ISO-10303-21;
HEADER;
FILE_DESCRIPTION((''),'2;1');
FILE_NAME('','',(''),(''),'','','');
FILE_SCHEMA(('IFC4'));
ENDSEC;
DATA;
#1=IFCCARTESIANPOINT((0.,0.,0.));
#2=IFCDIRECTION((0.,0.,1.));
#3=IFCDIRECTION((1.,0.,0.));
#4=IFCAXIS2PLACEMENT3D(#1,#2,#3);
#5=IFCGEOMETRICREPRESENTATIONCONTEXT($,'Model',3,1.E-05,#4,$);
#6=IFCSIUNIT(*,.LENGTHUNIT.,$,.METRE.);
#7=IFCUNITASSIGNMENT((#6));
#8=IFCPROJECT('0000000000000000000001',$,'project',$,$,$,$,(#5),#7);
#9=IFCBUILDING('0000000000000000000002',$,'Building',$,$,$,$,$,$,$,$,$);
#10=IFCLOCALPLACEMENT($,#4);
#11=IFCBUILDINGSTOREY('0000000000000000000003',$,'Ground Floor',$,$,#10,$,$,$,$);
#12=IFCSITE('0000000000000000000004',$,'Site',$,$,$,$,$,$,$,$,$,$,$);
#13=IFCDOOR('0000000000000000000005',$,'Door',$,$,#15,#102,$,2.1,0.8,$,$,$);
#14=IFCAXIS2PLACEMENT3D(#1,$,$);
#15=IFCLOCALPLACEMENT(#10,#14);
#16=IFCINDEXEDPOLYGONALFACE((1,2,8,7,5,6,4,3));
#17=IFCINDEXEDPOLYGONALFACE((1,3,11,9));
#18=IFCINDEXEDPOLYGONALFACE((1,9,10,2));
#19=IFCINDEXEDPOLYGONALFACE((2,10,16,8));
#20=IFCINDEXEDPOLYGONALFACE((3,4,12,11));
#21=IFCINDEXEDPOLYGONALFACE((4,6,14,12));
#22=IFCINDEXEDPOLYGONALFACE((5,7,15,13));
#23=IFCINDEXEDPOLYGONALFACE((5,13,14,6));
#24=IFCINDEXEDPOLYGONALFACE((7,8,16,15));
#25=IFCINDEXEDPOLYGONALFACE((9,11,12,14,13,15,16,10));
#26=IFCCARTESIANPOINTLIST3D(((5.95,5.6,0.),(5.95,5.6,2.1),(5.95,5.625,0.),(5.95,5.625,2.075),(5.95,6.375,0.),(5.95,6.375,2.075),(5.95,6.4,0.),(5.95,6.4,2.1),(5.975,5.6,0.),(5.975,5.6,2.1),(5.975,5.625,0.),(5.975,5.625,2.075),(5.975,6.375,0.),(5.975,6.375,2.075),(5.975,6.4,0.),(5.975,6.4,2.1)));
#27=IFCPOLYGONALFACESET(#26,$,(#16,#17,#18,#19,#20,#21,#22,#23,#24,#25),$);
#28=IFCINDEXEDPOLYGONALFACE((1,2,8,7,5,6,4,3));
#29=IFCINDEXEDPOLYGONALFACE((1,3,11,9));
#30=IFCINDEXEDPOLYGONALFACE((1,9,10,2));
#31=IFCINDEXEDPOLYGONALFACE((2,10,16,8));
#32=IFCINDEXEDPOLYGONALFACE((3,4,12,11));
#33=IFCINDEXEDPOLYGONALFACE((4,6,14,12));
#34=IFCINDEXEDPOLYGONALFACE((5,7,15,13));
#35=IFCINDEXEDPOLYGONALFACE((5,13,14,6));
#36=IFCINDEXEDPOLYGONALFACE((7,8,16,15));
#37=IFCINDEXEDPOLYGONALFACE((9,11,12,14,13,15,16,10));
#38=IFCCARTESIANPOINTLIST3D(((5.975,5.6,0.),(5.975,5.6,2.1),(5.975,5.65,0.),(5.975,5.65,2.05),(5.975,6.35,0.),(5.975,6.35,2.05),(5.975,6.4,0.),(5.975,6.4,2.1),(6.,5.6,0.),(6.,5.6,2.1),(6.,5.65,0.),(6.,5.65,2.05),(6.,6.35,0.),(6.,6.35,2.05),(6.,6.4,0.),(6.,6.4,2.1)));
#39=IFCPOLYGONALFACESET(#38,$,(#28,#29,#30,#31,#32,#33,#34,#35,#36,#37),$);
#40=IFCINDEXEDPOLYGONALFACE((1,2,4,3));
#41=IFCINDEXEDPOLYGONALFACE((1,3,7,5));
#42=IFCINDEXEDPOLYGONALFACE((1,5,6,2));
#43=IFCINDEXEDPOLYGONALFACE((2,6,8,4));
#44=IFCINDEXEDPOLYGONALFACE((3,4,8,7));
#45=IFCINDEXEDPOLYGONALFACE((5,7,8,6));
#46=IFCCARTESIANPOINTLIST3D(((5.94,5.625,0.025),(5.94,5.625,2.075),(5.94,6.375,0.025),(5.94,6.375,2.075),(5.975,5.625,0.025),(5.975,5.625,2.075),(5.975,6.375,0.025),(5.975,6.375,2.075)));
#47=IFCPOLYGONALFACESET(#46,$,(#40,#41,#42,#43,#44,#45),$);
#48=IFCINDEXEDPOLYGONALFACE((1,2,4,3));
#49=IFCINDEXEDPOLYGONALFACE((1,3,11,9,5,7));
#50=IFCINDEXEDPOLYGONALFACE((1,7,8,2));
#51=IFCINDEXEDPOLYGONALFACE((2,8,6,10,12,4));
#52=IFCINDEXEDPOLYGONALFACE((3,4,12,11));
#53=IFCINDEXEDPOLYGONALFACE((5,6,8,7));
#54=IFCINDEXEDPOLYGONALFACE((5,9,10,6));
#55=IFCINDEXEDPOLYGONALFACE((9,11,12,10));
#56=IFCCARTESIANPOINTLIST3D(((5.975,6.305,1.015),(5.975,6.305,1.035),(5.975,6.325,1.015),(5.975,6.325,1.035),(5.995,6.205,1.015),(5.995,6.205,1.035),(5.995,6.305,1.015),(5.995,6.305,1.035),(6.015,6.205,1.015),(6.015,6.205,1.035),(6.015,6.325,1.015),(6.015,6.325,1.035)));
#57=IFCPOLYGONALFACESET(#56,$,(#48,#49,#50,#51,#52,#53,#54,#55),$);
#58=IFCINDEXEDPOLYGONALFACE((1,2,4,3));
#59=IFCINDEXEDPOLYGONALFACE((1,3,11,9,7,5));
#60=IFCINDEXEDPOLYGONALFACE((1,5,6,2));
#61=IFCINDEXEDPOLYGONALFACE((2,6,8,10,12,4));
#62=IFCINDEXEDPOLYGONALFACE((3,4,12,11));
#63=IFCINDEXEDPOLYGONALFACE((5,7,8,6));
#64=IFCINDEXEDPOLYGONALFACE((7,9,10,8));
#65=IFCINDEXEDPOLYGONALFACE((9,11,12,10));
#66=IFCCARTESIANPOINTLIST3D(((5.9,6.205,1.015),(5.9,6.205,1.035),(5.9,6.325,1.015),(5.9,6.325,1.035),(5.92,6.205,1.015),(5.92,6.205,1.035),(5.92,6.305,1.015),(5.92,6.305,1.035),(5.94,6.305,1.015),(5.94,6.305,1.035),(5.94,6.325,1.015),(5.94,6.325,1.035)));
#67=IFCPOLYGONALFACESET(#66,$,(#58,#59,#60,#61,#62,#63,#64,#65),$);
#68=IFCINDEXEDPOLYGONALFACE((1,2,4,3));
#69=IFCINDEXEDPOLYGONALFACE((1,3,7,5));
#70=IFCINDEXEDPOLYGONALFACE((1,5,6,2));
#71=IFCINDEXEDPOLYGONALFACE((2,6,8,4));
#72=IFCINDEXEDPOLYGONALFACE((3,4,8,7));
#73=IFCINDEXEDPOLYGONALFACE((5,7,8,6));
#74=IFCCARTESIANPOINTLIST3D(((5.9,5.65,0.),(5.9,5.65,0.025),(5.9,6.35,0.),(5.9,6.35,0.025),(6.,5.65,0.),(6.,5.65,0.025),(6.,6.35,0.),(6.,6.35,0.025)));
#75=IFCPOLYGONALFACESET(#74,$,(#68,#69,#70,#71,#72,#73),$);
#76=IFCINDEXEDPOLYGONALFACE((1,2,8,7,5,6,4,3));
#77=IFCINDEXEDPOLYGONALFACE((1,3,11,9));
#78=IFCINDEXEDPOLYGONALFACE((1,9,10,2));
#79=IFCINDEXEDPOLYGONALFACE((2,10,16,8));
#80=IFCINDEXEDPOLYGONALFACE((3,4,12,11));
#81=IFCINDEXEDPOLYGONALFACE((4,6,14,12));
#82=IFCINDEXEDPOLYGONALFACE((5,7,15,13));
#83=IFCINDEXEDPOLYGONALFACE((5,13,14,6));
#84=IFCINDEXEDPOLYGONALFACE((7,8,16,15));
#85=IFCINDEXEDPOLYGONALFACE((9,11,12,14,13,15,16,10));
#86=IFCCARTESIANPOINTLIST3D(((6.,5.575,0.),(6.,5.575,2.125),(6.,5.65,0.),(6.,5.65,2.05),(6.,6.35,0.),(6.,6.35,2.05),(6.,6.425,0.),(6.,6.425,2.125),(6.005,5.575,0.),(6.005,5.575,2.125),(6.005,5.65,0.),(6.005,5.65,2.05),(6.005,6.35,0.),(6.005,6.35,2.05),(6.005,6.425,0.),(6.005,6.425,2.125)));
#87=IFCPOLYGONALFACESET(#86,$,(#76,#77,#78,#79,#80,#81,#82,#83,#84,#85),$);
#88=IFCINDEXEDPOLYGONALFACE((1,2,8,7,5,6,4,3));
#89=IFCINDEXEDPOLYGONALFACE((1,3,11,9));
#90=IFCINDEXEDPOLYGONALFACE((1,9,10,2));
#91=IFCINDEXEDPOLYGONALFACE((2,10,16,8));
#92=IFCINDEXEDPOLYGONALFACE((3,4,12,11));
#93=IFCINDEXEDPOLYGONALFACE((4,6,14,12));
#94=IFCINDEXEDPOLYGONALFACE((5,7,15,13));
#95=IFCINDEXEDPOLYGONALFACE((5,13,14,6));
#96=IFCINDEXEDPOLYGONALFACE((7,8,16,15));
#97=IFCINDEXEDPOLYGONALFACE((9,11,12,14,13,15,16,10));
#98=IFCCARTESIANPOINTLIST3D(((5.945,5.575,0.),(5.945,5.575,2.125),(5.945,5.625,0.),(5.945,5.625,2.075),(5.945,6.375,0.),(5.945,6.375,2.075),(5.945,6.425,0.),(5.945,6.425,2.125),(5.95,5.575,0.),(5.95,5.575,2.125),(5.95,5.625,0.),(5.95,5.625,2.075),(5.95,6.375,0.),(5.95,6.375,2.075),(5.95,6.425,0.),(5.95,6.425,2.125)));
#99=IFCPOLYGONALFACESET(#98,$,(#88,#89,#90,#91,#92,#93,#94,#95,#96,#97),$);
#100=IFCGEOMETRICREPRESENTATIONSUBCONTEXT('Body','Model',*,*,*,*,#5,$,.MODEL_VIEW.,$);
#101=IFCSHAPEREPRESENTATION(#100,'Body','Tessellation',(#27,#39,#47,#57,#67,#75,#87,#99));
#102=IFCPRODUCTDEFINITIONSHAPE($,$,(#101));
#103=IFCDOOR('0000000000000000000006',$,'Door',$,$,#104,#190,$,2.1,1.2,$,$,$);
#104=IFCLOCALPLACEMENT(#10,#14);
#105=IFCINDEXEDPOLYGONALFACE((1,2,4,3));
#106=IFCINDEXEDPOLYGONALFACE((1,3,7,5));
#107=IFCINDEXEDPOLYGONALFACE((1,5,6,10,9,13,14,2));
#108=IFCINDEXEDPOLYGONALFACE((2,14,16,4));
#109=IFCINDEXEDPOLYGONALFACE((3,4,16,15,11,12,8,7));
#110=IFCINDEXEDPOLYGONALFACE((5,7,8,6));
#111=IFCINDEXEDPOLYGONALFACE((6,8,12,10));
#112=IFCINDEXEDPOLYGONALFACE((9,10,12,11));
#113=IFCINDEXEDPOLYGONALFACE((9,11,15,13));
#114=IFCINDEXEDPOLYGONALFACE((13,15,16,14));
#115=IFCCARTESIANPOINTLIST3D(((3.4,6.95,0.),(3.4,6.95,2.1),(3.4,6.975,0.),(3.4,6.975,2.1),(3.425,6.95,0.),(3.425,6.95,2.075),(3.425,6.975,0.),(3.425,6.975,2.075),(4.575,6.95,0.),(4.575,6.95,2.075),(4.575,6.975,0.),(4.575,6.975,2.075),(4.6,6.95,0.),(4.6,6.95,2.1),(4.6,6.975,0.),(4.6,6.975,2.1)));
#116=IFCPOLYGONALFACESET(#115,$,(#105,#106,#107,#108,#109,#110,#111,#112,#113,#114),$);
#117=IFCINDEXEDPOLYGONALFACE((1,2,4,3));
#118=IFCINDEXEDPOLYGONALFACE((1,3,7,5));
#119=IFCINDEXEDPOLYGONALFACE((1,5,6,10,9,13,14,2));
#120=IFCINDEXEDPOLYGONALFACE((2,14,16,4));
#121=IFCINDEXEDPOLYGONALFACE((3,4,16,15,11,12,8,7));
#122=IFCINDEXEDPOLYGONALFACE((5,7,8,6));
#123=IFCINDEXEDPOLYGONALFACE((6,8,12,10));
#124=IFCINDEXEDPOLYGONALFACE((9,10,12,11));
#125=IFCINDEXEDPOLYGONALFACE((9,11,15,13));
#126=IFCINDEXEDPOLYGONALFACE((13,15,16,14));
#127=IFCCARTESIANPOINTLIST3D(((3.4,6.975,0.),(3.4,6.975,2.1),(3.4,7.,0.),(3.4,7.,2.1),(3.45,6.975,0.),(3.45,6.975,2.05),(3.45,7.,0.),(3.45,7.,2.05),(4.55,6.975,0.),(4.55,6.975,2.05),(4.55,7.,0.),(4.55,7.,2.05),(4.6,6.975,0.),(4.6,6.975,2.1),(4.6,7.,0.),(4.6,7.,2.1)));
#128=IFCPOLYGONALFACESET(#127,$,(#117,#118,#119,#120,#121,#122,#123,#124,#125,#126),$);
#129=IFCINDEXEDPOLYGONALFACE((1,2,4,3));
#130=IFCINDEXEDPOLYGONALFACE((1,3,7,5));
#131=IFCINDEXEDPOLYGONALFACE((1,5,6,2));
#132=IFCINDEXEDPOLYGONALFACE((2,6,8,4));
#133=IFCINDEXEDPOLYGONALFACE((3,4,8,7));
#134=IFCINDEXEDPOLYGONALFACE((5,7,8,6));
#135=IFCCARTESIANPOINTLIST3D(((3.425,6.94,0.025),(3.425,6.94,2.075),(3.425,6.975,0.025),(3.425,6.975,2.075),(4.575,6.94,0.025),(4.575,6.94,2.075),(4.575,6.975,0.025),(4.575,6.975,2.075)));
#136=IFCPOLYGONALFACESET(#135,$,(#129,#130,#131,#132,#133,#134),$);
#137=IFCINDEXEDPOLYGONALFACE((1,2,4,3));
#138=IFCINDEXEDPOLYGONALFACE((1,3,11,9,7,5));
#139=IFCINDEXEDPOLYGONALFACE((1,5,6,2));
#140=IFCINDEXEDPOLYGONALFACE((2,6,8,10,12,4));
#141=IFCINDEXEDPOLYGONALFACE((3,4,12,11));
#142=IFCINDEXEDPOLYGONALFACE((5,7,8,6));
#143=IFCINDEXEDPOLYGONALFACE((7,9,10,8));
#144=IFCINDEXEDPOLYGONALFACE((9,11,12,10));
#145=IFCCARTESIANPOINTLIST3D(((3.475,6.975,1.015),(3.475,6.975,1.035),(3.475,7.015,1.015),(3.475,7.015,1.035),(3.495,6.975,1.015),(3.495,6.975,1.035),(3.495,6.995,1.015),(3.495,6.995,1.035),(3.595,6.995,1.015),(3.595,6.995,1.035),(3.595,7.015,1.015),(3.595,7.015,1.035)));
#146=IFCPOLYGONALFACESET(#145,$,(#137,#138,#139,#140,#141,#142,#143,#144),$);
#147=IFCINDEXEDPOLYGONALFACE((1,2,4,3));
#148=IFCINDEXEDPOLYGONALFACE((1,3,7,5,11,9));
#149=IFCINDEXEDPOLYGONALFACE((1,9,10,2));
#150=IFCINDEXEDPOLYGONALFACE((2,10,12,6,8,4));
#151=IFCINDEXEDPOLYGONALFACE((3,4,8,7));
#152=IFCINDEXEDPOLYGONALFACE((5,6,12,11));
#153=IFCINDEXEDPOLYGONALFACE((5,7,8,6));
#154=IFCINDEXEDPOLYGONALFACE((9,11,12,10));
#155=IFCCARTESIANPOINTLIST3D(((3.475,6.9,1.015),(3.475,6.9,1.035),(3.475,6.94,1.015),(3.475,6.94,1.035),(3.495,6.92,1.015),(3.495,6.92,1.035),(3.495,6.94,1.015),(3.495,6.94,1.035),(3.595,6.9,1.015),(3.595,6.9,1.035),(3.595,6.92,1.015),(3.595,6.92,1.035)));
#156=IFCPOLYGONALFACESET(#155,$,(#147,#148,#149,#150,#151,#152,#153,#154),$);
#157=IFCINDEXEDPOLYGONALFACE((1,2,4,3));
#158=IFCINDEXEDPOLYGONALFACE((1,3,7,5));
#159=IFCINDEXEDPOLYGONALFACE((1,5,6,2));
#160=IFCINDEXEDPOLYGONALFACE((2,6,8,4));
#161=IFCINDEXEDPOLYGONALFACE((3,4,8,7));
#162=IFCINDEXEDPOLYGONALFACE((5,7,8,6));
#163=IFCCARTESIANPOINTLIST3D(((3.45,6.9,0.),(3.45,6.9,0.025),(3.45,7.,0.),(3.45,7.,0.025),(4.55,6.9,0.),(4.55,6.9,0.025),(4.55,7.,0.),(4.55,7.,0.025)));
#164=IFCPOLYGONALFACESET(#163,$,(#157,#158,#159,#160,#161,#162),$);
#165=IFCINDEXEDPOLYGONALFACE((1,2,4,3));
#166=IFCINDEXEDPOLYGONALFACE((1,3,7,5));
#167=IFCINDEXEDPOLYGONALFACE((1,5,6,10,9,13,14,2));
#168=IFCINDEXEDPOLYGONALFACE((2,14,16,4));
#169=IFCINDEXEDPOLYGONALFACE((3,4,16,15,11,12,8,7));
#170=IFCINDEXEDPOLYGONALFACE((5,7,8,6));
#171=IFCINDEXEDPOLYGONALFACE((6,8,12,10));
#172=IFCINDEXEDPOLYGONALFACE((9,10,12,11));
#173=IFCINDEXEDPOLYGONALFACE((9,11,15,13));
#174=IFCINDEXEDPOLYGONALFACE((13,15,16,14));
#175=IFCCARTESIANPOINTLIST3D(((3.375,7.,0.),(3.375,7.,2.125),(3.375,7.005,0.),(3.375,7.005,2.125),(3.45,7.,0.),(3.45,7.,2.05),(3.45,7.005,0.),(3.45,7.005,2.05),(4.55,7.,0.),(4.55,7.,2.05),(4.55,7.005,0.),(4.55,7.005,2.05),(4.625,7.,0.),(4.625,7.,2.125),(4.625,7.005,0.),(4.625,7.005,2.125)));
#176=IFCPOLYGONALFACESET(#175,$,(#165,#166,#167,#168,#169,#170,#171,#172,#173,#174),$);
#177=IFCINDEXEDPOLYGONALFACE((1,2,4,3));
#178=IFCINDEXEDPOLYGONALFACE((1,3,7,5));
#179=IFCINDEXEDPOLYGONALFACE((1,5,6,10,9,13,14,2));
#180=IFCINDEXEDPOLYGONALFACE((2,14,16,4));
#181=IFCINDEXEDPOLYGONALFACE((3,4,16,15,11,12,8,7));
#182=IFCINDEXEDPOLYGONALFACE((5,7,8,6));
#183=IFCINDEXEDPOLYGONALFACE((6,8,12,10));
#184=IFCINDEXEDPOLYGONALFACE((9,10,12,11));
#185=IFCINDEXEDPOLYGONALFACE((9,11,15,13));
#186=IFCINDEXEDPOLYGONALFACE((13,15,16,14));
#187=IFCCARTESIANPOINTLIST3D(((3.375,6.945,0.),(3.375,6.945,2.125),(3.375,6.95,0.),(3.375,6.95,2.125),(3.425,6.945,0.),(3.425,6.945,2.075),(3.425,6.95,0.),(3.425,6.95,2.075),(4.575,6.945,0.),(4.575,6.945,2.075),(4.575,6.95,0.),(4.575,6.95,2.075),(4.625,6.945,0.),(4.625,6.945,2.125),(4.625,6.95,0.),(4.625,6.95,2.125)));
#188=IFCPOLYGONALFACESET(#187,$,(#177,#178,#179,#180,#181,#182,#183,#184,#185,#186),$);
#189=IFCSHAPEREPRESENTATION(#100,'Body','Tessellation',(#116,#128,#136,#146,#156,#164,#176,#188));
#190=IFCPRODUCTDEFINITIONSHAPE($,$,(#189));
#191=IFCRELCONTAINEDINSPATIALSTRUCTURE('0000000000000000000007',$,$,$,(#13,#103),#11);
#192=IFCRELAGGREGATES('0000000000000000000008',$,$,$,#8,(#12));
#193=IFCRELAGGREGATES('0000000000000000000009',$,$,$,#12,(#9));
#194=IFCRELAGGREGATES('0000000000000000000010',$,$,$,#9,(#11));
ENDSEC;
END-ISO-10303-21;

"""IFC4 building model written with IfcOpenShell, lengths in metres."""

from ifc_helpers import new_model, si_unit, frame, origin_with_axes, place, context, subcontext, project, spatial, line, indexed_curve, outline, extrude, element, save


model = new_model("IFC4")

# Units and contexts
model_context = context("Model", 3, precision=1e-05, world=origin_with_axes())
body_context = subcontext(model_context, "Body", "Model", "MODEL_VIEW")
ifc_project = project(units=[si_unit("LENGTHUNIT", "METRE")], contexts=[model_context])

# Site, building, storey
site = spatial("IfcSite", under=ifc_project, Name="Site")
building = spatial("IfcBuilding", under=site, Name="Building")
storey_placement = place(None, origin_with_axes())
storey = spatial("IfcBuildingStorey", under=building, at=storey_placement, Name="Ground Floor")

# Doors
door_1_placement = place(storey_placement, frame((6.0, 5.6, 0.0), z_axis=(0.0, 0.0, 1.0), x_axis=(0.0, 1.0, 0.0)))
element("IfcDoor", 1, at=door_1_placement, inside=storey, Name="Door", OverallHeight=2.1, OverallWidth=0.8, context=body_context, shape_type="SweptSolid", body=[
    extrude(outline(indexed_curve([(0.0, 0.0), (0.0, 2.1), (0.8, 2.1), (0.8, 0.0), (0.775, 0.0), (0.775, 2.075), (0.025, 2.075), (0.025, 0.0)], segments=[line(1, 2, 3, 4, 5, 6, 7, 8, 1)])), frame((0.0, 0.025, 0.0), z_axis=(0.0, -1.0, 0.0), x_axis=(1.0, 0.0, 0.0)), (0.0, 0.0, -1.0), 0.025),
    extrude(outline(indexed_curve([(0.0, 0.0), (0.0, 2.1), (0.8, 2.1), (0.8, 0.0), (0.75, 0.0), (0.75, 2.05), (0.05, 2.05), (0.05, 0.0)], segments=[line(1, 2, 3, 4, 5, 6, 7, 8, 1)])), frame((0.0, 0.0, 0.0), z_axis=(0.0, -1.0, 0.0), x_axis=(1.0, 0.0, 0.0)), (0.0, 0.0, -1.0), 0.025),
    extrude(outline(indexed_curve([(0.0, 0.0), (0.75, 0.0), (0.75, 0.035), (0.0, 0.035)], segments=[line(1, 2, 3, 4, 1)])), frame((0.025, 0.025, 0.025), z_axis=(0.0, 0.0, 1.0), x_axis=(1.0, 0.0, 0.0)), (0.0, 0.0, 1.0), 2.05),
    extrude(outline(indexed_curve([(0.0, 0.0), (0.0, -0.04), (-0.12, -0.04), (-0.12, -0.02), (-0.02, -0.02), (-0.02, 0.0)], segments=[line(1, 2, 3, 4, 5, 6, 1)])), frame((0.725, 0.025, 1.015), z_axis=(0.0, 0.0, 1.0), x_axis=(1.0, 0.0, 0.0)), (0.0, 0.0, 1.0), 0.02),
    extrude(outline(indexed_curve([(0.0, 0.0), (0.0, 0.04), (-0.12, 0.04), (-0.12, 0.02), (-0.02, 0.02), (-0.02, 0.0)], segments=[line(1, 2, 3, 4, 5, 6, 1)])), frame((0.725, 0.06, 1.015), z_axis=(0.0, 0.0, 1.0), x_axis=(1.0, 0.0, 0.0)), (0.0, 0.0, 1.0), 0.02),
    extrude(outline(indexed_curve([(0.0, 0.0), (0.7, 0.0), (0.7, 0.1), (0.0, 0.1)], segments=[line(1, 2, 3, 4, 1)])), frame((0.05, 0.0, 0.0), z_axis=(0.0, 0.0, 1.0), x_axis=(1.0, 0.0, 0.0)), (0.0, 0.0, 1.0), 0.025),
    extrude(outline(indexed_curve([(0.0, 0.0), (0.0, 2.125), (0.85, 2.125), (0.85, 0.0), (0.775, 0.0), (0.775, 2.05), (0.075, 2.05), (0.075, 0.0)], segments=[line(1, 2, 3, 4, 5, 6, 7, 8, 1)])), frame((-0.025, -0.005, 0.0), z_axis=(0.0, -1.0, 0.0), x_axis=(1.0, 0.0, 0.0)), (0.0, 0.0, -1.0), 0.005),
    extrude(outline(indexed_curve([(0.0, 0.0), (0.0, 2.125), (0.85, 2.125), (0.85, 0.0), (0.8, 0.0), (0.8, 2.075), (0.05, 2.075), (0.05, 0.0)], segments=[line(1, 2, 3, 4, 5, 6, 7, 8, 1)])), frame((-0.025, 0.05, 0.0), z_axis=(0.0, -1.0, 0.0), x_axis=(1.0, 0.0, 0.0)), (0.0, 0.0, -1.0), 0.005),
])
door_2_placement = place(storey_placement, frame((4.6, 7.0, 0.0), z_axis=(0.0, 0.0, 1.0), x_axis=(-1.0, 0.0, 0.0)))
element("IfcDoor", 2, at=door_2_placement, inside=storey, Name="Door", OverallHeight=2.1, OverallWidth=1.2, context=body_context, shape_type="SweptSolid", body=[
    extrude(outline(indexed_curve([(0.0, 0.0), (0.0, 2.1), (1.2, 2.1), (1.2, 0.0), (1.175, 0.0), (1.175, 2.075), (0.025, 2.075), (0.025, 0.0)], segments=[line(1, 2, 3, 4, 5, 6, 7, 8, 1)])), frame((0.0, 0.025, 0.0), z_axis=(0.0, -1.0, 0.0), x_axis=(1.0, 0.0, 0.0)), (0.0, 0.0, -1.0), 0.025),
    extrude(outline(indexed_curve([(0.0, 0.0), (0.0, 2.1), (1.2, 2.1), (1.2, 0.0), (1.15, 0.0), (1.15, 2.05), (0.05, 2.05), (0.05, 0.0)], segments=[line(1, 2, 3, 4, 5, 6, 7, 8, 1)])), frame((0.0, 0.0, 0.0), z_axis=(0.0, -1.0, 0.0), x_axis=(1.0, 0.0, 0.0)), (0.0, 0.0, -1.0), 0.025),
    extrude(outline(indexed_curve([(0.0, 0.0), (1.15, 0.0), (1.15, 0.035), (0.0, 0.035)], segments=[line(1, 2, 3, 4, 1)])), frame((0.025, 0.025, 0.025), z_axis=(0.0, 0.0, 1.0), x_axis=(1.0, 0.0, 0.0)), (0.0, 0.0, 1.0), 2.05),
    extrude(outline(indexed_curve([(0.0, 0.0), (0.0, -0.04), (-0.12, -0.04), (-0.12, -0.02), (-0.02, -0.02), (-0.02, 0.0)], segments=[line(1, 2, 3, 4, 5, 6, 1)])), frame((1.125, 0.025, 1.015), z_axis=(0.0, 0.0, 1.0), x_axis=(1.0, 0.0, 0.0)), (0.0, 0.0, 1.0), 0.02),
    extrude(outline(indexed_curve([(0.0, 0.0), (0.0, 0.04), (-0.12, 0.04), (-0.12, 0.02), (-0.02, 0.02), (-0.02, 0.0)], segments=[line(1, 2, 3, 4, 5, 6, 1)])), frame((1.125, 0.06, 1.015), z_axis=(0.0, 0.0, 1.0), x_axis=(1.0, 0.0, 0.0)), (0.0, 0.0, 1.0), 0.02),
    extrude(outline(indexed_curve([(0.0, 0.0), (1.1, 0.0), (1.1, 0.1), (0.0, 0.1)], segments=[line(1, 2, 3, 4, 1)])), frame((0.05, 0.0, 0.0), z_axis=(0.0, 0.0, 1.0), x_axis=(1.0, 0.0, 0.0)), (0.0, 0.0, 1.0), 0.025),
    extrude(outline(indexed_curve([(0.0, 0.0), (0.0, 2.125), (1.25, 2.125), (1.25, 0.0), (1.175, 0.0), (1.175, 2.05), (0.075, 2.05), (0.075, 0.0)], segments=[line(1, 2, 3, 4, 5, 6, 7, 8, 1)])), frame((-0.025, -0.005, 0.0), z_axis=(0.0, -1.0, 0.0), x_axis=(1.0, 0.0, 0.0)), (0.0, 0.0, -1.0), 0.005),
    extrude(outline(indexed_curve([(0.0, 0.0), (0.0, 2.125), (1.25, 2.125), (1.25, 0.0), (1.2, 0.0), (1.2, 2.075), (0.05, 2.075), (0.05, 0.0)], segments=[line(1, 2, 3, 4, 5, 6, 7, 8, 1)])), frame((-0.025, 0.05, 0.0), z_axis=(0.0, -1.0, 0.0), x_axis=(1.0, 0.0, 0.0)), (0.0, 0.0, -1.0), 0.005),
])

save(model, "model.ifc")
